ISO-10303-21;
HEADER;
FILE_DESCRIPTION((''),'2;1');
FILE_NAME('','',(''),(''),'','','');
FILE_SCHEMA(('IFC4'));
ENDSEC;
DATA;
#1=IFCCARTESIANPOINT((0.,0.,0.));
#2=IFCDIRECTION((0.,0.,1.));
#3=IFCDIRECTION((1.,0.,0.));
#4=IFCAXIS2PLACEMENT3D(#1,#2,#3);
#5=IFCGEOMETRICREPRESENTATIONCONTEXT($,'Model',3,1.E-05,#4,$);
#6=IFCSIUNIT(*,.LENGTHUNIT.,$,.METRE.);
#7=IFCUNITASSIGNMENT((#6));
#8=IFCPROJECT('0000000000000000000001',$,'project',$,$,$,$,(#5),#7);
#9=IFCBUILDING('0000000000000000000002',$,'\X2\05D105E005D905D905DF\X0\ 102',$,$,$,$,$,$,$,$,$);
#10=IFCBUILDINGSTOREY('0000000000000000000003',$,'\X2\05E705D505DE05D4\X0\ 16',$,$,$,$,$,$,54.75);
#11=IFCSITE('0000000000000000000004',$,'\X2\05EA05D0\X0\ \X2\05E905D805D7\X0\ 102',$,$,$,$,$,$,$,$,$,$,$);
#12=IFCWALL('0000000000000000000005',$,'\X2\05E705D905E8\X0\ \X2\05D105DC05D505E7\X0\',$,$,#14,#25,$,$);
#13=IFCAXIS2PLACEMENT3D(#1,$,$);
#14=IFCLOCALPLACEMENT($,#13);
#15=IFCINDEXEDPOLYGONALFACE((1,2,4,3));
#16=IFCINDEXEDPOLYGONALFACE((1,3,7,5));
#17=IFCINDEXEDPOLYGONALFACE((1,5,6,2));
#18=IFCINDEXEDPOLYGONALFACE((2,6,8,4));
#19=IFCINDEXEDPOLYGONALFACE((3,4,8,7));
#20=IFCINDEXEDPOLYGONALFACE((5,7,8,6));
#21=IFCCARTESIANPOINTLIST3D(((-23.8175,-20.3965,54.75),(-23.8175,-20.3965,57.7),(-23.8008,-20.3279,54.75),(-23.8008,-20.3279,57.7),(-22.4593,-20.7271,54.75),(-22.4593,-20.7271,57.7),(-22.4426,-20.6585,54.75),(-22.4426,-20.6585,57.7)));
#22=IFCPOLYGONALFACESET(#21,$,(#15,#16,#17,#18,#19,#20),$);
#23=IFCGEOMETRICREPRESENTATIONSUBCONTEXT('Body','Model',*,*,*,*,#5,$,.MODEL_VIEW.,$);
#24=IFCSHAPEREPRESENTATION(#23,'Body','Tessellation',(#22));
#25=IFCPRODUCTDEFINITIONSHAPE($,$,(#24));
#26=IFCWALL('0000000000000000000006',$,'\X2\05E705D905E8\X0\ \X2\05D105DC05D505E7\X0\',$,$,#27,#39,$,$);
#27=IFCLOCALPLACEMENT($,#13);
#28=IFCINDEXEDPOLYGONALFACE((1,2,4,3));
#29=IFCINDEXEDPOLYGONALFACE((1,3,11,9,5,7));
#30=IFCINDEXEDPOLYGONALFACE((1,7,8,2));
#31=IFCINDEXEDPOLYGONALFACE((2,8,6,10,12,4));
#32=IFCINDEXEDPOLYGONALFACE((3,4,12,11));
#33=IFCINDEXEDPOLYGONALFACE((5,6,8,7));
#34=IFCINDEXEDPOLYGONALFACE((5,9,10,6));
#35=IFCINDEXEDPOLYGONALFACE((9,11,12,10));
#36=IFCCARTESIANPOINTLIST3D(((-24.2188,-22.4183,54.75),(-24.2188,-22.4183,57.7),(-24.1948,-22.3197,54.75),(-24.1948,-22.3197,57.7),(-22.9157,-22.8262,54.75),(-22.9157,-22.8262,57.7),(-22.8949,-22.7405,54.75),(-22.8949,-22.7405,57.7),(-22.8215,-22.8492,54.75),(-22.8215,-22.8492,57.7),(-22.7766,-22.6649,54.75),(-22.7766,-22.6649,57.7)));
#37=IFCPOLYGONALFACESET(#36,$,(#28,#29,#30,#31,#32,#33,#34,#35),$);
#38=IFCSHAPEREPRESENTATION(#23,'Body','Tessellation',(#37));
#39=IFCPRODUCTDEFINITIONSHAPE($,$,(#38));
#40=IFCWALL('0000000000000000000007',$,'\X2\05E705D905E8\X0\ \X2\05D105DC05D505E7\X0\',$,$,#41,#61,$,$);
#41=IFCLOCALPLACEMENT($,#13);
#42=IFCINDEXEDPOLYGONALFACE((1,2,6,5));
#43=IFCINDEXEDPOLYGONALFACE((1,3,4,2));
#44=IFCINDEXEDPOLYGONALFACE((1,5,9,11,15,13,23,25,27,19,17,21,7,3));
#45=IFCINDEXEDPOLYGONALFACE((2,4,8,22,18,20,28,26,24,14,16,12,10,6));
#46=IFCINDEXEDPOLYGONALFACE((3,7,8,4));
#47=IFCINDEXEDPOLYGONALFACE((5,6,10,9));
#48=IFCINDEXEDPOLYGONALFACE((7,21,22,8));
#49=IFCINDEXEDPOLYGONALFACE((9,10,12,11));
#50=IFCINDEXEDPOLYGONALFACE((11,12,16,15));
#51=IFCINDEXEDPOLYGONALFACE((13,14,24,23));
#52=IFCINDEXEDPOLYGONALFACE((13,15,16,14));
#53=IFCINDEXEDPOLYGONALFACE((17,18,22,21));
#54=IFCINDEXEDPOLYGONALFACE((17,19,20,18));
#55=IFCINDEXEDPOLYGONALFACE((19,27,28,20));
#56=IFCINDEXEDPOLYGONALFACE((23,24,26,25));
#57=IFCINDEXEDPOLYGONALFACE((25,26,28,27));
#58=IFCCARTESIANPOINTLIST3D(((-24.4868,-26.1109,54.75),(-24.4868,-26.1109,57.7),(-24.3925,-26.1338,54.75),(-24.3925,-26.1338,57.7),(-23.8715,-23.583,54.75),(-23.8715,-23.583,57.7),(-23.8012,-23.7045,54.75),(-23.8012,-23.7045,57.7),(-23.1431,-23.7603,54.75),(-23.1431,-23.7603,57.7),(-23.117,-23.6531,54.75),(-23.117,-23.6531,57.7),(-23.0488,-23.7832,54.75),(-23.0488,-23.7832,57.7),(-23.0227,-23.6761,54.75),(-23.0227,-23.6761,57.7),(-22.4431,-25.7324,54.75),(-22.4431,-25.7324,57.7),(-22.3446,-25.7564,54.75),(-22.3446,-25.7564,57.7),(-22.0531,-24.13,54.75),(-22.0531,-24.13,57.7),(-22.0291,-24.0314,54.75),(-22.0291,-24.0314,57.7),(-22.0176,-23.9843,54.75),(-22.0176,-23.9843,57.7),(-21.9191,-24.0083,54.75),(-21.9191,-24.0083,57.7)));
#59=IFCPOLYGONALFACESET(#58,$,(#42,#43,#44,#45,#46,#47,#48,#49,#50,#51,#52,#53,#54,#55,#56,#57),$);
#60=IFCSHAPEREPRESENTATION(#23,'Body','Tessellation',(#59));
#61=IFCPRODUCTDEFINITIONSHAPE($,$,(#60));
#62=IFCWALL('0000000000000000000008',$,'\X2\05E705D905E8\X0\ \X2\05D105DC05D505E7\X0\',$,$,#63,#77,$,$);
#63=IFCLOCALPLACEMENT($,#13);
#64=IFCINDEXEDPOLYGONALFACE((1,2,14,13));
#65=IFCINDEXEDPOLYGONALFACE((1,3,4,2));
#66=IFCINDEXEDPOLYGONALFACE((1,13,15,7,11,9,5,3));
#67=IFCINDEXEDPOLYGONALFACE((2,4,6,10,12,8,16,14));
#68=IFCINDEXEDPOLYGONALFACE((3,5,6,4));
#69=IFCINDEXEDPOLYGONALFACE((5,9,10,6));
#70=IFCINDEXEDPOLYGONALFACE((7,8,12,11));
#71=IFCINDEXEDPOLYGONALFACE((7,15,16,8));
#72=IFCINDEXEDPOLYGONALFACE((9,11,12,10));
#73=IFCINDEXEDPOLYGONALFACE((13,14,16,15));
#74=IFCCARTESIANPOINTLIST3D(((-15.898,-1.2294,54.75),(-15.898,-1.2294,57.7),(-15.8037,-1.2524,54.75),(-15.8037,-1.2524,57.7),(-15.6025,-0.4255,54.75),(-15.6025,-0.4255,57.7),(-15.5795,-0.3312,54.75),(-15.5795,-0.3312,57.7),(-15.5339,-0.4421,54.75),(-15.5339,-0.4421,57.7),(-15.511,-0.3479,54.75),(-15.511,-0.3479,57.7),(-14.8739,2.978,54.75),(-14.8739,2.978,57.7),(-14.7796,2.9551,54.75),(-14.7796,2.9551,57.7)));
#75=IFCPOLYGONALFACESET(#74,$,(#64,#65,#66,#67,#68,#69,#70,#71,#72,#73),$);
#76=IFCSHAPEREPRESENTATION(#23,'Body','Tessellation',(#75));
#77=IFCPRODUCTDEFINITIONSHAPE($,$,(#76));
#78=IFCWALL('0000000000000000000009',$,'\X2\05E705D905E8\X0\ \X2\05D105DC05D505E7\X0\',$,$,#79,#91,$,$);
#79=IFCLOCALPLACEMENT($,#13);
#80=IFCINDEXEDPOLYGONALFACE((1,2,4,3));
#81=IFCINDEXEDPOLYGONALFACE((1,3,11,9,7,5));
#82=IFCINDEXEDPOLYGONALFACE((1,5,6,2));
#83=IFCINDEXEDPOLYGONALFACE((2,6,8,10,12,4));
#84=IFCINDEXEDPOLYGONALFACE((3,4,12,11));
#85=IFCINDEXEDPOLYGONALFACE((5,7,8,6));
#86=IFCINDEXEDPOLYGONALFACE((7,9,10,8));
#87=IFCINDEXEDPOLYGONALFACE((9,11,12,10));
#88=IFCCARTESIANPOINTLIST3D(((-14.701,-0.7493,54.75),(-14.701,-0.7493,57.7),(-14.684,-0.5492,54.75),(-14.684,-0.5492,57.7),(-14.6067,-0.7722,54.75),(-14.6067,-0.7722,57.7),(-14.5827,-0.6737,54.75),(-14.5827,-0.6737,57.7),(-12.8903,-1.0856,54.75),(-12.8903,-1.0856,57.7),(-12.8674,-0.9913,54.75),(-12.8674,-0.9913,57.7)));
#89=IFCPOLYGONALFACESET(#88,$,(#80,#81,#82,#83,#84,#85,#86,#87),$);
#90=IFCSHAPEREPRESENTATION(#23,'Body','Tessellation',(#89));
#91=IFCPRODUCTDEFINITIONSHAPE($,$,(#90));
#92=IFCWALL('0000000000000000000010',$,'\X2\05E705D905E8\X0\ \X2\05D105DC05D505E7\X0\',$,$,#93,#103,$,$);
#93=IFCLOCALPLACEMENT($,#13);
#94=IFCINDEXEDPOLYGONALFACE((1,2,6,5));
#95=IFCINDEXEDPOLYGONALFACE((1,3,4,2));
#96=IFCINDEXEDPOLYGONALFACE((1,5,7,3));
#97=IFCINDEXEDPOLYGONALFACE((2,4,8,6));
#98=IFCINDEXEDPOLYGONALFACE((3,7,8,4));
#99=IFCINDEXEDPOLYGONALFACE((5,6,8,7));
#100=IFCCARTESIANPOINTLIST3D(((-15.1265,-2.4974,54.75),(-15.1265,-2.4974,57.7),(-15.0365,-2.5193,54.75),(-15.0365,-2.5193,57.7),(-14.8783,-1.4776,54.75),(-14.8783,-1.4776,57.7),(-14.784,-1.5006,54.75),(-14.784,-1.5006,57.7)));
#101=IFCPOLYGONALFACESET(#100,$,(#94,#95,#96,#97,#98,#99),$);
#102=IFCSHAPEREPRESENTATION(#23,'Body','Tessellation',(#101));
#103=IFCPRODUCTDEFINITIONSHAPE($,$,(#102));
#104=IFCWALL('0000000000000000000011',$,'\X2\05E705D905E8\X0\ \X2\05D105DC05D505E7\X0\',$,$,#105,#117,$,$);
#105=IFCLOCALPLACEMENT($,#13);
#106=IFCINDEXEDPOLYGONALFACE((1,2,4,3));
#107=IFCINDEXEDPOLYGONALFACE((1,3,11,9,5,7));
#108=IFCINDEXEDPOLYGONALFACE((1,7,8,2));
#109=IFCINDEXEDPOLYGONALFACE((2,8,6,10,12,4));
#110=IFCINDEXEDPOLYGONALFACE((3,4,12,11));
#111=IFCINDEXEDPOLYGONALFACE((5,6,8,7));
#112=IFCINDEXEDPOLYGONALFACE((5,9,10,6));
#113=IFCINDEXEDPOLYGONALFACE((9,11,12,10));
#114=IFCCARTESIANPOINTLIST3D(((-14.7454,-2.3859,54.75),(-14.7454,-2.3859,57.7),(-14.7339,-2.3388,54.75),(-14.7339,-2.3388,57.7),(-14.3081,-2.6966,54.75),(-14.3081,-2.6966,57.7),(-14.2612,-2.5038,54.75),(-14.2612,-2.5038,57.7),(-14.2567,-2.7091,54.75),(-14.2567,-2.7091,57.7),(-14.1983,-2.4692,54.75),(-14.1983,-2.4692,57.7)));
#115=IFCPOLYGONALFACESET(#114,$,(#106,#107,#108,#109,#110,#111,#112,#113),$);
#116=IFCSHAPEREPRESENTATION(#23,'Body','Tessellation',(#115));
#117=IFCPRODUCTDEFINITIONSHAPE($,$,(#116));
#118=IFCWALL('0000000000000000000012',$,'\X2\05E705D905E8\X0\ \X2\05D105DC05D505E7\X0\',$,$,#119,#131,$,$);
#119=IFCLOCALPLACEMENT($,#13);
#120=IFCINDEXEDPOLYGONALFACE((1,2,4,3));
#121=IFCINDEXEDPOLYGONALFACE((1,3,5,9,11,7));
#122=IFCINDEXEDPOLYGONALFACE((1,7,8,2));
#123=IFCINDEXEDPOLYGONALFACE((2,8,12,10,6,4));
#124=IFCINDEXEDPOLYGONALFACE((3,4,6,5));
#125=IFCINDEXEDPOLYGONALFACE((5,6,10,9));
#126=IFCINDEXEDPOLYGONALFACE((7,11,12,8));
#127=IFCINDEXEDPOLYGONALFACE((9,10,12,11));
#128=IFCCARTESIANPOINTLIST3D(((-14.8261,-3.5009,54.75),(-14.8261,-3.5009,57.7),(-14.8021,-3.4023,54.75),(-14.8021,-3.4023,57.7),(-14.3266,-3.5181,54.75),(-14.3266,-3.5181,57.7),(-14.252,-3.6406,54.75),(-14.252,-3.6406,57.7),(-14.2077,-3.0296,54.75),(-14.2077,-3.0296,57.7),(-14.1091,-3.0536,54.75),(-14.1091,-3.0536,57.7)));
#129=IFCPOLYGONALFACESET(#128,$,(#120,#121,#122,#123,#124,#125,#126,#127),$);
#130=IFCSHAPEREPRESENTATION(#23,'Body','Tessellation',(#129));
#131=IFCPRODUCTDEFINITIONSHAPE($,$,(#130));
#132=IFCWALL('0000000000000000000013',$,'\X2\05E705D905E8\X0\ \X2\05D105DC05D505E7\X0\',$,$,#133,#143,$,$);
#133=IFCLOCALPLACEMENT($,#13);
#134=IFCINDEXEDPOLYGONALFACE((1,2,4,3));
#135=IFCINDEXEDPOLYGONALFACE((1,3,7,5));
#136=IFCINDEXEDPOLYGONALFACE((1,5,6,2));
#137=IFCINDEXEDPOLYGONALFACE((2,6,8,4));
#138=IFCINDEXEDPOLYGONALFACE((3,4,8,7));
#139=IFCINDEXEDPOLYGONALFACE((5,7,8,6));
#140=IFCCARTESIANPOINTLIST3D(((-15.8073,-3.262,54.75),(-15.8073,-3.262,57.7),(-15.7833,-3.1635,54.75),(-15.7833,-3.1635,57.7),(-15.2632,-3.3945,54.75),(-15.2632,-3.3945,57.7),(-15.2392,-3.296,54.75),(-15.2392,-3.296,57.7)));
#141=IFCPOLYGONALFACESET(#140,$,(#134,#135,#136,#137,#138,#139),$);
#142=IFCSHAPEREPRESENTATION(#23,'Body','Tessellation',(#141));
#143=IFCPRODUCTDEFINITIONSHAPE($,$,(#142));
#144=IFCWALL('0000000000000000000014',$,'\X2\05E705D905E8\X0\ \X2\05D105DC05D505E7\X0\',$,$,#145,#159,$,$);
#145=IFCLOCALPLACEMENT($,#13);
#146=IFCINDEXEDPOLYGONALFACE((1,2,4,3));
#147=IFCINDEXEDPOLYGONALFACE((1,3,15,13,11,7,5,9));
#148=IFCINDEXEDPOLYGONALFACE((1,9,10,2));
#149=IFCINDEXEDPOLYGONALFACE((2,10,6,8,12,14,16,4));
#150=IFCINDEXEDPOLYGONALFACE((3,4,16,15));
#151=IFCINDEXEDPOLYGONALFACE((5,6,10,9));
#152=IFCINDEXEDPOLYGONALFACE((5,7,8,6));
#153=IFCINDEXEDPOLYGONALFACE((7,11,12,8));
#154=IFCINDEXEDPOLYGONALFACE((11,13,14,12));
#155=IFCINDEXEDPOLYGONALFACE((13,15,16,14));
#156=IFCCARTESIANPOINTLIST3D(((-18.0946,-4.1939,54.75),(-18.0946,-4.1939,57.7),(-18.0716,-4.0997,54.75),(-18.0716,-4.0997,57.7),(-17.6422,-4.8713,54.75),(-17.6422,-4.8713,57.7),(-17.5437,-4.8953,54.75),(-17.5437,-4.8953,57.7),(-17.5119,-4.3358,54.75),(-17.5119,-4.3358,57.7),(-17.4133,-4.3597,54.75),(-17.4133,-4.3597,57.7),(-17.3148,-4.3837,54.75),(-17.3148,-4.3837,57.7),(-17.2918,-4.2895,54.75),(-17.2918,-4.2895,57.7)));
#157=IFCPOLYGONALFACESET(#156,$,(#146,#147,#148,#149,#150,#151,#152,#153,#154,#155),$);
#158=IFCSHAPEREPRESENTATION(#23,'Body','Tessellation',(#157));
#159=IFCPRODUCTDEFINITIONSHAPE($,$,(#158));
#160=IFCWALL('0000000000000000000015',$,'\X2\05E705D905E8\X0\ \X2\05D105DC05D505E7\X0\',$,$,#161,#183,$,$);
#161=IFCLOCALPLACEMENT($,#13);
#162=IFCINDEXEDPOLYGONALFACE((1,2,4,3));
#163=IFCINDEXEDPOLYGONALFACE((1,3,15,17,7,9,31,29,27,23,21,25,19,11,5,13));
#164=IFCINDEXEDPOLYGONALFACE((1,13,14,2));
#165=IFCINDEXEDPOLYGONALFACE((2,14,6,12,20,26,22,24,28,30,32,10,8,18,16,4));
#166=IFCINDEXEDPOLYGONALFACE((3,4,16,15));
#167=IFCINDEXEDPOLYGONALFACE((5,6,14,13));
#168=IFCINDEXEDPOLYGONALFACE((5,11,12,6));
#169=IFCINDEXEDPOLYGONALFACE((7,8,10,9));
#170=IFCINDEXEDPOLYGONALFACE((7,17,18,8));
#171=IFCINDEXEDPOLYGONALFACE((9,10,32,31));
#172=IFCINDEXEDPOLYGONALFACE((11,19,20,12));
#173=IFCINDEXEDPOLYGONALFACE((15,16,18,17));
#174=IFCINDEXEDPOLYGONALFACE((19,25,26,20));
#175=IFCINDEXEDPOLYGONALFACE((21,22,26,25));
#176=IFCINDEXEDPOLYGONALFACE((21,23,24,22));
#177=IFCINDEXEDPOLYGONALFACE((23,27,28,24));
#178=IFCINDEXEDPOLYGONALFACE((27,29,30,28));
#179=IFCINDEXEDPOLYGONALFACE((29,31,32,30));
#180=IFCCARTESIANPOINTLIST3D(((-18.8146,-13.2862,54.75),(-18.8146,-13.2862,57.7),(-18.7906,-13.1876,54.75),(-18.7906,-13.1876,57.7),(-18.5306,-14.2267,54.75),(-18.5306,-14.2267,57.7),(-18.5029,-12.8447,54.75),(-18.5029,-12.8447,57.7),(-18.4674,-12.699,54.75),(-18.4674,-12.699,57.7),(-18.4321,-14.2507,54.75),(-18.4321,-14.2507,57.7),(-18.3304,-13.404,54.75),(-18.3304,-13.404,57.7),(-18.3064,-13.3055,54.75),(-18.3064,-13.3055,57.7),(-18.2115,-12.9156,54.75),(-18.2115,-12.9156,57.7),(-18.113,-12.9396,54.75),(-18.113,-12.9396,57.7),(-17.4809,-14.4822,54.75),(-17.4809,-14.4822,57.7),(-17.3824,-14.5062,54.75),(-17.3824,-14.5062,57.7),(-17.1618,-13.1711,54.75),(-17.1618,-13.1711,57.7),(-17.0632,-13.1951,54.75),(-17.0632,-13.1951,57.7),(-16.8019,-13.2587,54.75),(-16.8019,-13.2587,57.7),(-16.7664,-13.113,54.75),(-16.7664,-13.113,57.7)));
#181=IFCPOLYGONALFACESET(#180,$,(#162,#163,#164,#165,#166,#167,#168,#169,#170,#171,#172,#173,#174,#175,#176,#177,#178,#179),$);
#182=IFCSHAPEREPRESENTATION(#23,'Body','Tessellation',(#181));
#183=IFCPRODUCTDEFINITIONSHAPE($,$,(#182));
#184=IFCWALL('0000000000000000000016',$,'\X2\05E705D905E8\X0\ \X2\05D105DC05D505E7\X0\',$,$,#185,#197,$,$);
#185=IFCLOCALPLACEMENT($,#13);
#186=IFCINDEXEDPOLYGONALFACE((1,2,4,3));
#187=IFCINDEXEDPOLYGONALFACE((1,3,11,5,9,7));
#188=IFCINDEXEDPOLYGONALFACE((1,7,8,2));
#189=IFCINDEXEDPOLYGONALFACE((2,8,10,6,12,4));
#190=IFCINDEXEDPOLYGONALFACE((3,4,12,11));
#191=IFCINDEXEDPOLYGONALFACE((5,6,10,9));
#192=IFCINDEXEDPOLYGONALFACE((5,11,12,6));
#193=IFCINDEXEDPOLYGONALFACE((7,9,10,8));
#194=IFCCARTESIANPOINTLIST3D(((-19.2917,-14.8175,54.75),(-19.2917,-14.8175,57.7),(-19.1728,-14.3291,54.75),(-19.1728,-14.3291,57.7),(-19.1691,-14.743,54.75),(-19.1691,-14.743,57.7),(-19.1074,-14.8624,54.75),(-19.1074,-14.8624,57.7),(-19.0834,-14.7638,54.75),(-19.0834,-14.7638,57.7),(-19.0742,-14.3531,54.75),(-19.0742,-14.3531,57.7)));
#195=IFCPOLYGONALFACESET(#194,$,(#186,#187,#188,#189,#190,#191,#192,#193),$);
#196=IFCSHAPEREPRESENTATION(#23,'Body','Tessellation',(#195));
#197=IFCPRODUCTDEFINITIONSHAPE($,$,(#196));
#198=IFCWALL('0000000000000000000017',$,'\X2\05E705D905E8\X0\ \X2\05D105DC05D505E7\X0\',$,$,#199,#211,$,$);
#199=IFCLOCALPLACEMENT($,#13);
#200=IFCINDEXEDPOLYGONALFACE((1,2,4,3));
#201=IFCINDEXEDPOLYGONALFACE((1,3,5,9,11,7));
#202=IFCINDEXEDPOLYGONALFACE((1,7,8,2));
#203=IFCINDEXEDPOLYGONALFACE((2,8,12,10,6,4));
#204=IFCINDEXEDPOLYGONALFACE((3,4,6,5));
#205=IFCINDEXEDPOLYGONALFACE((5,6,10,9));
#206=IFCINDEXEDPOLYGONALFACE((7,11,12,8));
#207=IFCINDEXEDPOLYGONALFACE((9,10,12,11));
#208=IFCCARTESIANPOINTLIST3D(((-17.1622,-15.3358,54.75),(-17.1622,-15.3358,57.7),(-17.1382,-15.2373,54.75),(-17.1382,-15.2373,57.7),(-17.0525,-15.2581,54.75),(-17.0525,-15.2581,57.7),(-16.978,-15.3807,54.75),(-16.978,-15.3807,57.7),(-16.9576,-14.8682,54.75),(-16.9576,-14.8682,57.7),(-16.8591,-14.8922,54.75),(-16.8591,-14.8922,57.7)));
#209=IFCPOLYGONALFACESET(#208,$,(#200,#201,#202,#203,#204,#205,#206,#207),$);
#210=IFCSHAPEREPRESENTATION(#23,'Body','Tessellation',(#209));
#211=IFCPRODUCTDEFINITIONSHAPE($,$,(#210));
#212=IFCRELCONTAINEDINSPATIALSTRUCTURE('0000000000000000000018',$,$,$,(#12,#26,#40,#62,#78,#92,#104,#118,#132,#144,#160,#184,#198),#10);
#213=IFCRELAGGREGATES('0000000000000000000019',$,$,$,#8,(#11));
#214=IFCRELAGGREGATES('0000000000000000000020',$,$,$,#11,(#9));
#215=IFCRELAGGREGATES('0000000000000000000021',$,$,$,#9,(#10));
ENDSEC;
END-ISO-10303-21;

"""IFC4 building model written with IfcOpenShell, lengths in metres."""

from ifc_helpers import new_model, si_unit, frame, origin_with_axes, context, subcontext, project, spatial, polyline, outline, extrude, element, save


model = new_model("IFC4")

# Units and contexts
model_context = context("Model", 3, precision=1e-05, world=origin_with_axes())
body_context = subcontext(model_context, "Body", "Model", "MODEL_VIEW")
ifc_project = project(units=[si_unit("LENGTHUNIT", "METRE")], contexts=[model_context])

# Site, building, storey
site = spatial("IfcSite", under=ifc_project, Name="תא שטח 102")
building = spatial("IfcBuilding", under=site, Name="בניין 102")
storey = spatial("IfcBuildingStorey", under=building, Name="קומה 16", Elevation=54.75)

# Walls
element("IfcWall", 1, inside=storey, Name="קיר בלוק", context=body_context, shape_type="SweptSolid", body=[
    extrude(outline(polyline([(-22.4426, -20.6585), (-23.8008, -20.3279), (-23.8175, -20.3965), (-22.4593, -20.7271), (-22.4426, -20.6585)])), frame((0.0, 0.0, 54.75)), (0.0, 0.0, 1.0), 2.95),
])
element("IfcWall", 2, inside=storey, Name="קיר בלוק", context=body_context, shape_type="SweptSolid", body=[
    extrude(outline(polyline([(-24.2188, -22.4183), (-22.8949, -22.7405), (-22.9157, -22.8262), (-22.8215, -22.8492), (-22.7766, -22.6649), (-24.1948, -22.3197), (-24.2188, -22.4183)])), frame((0.0, 0.0, 54.75)), (0.0, 0.0, 1.0), 2.95),
])
element("IfcWall", 3, inside=storey, Name="קיר בלוק", context=body_context, shape_type="SweptSolid", body=[
    extrude(outline(polyline([(-23.8012, -23.7045), (-22.0531, -24.13), (-22.4431, -25.7324), (-22.3446, -25.7564), (-21.9191, -24.0083), (-22.0176, -23.9843), (-22.0291, -24.0314), (-23.0488, -23.7832), (-23.0227, -23.6761), (-23.117, -23.6531), (-23.1431, -23.7603), (-23.8715, -23.583), (-24.4868, -26.1109), (-24.3925, -26.1338), (-23.8012, -23.7045)])), frame((0.0, 0.0, 54.75)), (0.0, 0.0, 1.0), 2.95),
])
element("IfcWall", 4, inside=storey, Name="קיר בלוק", context=body_context, shape_type="SweptSolid", body=[
    extrude(outline(polyline([(-14.8739, 2.978), (-15.898, -1.2294), (-15.8037, -1.2524), (-15.6025, -0.4255), (-15.5339, -0.4421), (-15.511, -0.3479), (-15.5795, -0.3312), (-14.7796, 2.9551), (-14.8739, 2.978)])), frame((0.0, 0.0, 54.75)), (0.0, 0.0, 1.0), 2.95),
])
element("IfcWall", 5, inside=storey, Name="קיר בלוק", context=body_context, shape_type="SweptSolid", body=[
    extrude(outline(polyline([(-14.701, -0.7493), (-14.6067, -0.7722), (-14.5827, -0.6737), (-12.8903, -1.0856), (-12.8674, -0.9913), (-14.684, -0.5492), (-14.701, -0.7493)])), frame((0.0, 0.0, 54.75)), (0.0, 0.0, 1.0), 2.95),
])
element("IfcWall", 6, inside=storey, Name="קיר בלוק", context=body_context, shape_type="SweptSolid", body=[
    extrude(outline(polyline([(-15.1265, -2.4974), (-15.0365, -2.5193), (-14.784, -1.5006), (-14.8783, -1.4776), (-15.1265, -2.4974)])), frame((0.0, 0.0, 54.75)), (0.0, 0.0, 1.0), 2.95),
])
element("IfcWall", 7, inside=storey, Name="קיר בלוק", context=body_context, shape_type="SweptSolid", body=[
    extrude(outline(polyline([(-14.7454, -2.3859), (-14.2612, -2.5038), (-14.3081, -2.6966), (-14.2567, -2.7091), (-14.1983, -2.4692), (-14.7339, -2.3388), (-14.7454, -2.3859)])), frame((0.0, 0.0, 54.75)), (0.0, 0.0, 1.0), 2.95),
])
element("IfcWall", 8, inside=storey, Name="קיר בלוק", context=body_context, shape_type="SweptSolid", body=[
    extrude(outline(polyline([(-14.8021, -3.4023), (-14.8261, -3.5009), (-14.252, -3.6406), (-14.1091, -3.0536), (-14.2077, -3.0296), (-14.3266, -3.5181), (-14.8021, -3.4023)])), frame((0.0, 0.0, 54.75)), (0.0, 0.0, 1.0), 2.95),
])
element("IfcWall", 9, inside=storey, Name="קיר בלוק", context=body_context, shape_type="SweptSolid", body=[
    extrude(outline(polyline([(-15.7833, -3.1635), (-15.8073, -3.262), (-15.2632, -3.3945), (-15.2392, -3.296), (-15.7833, -3.1635)])), frame((0.0, 0.0, 54.75)), (0.0, 0.0, 1.0), 2.95),
])
element("IfcWall", 10, inside=storey, Name="קיר בלוק", context=body_context, shape_type="SweptSolid", body=[
    extrude(outline(polyline([(-17.4133, -4.3597), (-17.3148, -4.3837), (-17.2918, -4.2895), (-18.0716, -4.0997), (-18.0946, -4.1939), (-17.5119, -4.3358), (-17.6422, -4.8713), (-17.5437, -4.8953), (-17.4133, -4.3597)])), frame((0.0, 0.0, 54.75)), (0.0, 0.0, 1.0), 2.95),
])
element("IfcWall", 11, inside=storey, Name="קיר בלוק", context=body_context, shape_type="SweptSolid", body=[
    extrude(outline(polyline([(-18.7906, -13.1876), (-18.8146, -13.2862), (-18.3304, -13.404), (-18.5306, -14.2267), (-18.4321, -14.2507), (-18.113, -12.9396), (-17.1618, -13.1711), (-17.4809, -14.4822), (-17.3824, -14.5062), (-17.0632, -13.1951), (-16.8019, -13.2587), (-16.7664, -13.113), (-18.4674, -12.699), (-18.5029, -12.8447), (-18.2115, -12.9156), (-18.3064, -13.3055), (-18.7906, -13.1876)])), frame((0.0, 0.0, 54.75)), (0.0, 0.0, 1.0), 2.95),
])
element("IfcWall", 12, inside=storey, Name="קיר בלוק", context=body_context, shape_type="SweptSolid", body=[
    extrude(outline(polyline([(-19.0834, -14.7638), (-19.1691, -14.743), (-19.0742, -14.3531), (-19.1728, -14.3291), (-19.2917, -14.8175), (-19.1074, -14.8624), (-19.0834, -14.7638)])), frame((0.0, 0.0, 54.75)), (0.0, 0.0, 1.0), 2.95),
])
element("IfcWall", 13, inside=storey, Name="קיר בלוק", context=body_context, shape_type="SweptSolid", body=[
    extrude(outline(polyline([(-16.978, -15.3807), (-16.8591, -14.8922), (-16.9576, -14.8682), (-17.0525, -15.2581), (-17.1382, -15.2373), (-17.1622, -15.3358), (-16.978, -15.3807)])), frame((0.0, 0.0, 54.75)), (0.0, 0.0, 1.0), 2.95),
])

save(model, "model.ifc")
